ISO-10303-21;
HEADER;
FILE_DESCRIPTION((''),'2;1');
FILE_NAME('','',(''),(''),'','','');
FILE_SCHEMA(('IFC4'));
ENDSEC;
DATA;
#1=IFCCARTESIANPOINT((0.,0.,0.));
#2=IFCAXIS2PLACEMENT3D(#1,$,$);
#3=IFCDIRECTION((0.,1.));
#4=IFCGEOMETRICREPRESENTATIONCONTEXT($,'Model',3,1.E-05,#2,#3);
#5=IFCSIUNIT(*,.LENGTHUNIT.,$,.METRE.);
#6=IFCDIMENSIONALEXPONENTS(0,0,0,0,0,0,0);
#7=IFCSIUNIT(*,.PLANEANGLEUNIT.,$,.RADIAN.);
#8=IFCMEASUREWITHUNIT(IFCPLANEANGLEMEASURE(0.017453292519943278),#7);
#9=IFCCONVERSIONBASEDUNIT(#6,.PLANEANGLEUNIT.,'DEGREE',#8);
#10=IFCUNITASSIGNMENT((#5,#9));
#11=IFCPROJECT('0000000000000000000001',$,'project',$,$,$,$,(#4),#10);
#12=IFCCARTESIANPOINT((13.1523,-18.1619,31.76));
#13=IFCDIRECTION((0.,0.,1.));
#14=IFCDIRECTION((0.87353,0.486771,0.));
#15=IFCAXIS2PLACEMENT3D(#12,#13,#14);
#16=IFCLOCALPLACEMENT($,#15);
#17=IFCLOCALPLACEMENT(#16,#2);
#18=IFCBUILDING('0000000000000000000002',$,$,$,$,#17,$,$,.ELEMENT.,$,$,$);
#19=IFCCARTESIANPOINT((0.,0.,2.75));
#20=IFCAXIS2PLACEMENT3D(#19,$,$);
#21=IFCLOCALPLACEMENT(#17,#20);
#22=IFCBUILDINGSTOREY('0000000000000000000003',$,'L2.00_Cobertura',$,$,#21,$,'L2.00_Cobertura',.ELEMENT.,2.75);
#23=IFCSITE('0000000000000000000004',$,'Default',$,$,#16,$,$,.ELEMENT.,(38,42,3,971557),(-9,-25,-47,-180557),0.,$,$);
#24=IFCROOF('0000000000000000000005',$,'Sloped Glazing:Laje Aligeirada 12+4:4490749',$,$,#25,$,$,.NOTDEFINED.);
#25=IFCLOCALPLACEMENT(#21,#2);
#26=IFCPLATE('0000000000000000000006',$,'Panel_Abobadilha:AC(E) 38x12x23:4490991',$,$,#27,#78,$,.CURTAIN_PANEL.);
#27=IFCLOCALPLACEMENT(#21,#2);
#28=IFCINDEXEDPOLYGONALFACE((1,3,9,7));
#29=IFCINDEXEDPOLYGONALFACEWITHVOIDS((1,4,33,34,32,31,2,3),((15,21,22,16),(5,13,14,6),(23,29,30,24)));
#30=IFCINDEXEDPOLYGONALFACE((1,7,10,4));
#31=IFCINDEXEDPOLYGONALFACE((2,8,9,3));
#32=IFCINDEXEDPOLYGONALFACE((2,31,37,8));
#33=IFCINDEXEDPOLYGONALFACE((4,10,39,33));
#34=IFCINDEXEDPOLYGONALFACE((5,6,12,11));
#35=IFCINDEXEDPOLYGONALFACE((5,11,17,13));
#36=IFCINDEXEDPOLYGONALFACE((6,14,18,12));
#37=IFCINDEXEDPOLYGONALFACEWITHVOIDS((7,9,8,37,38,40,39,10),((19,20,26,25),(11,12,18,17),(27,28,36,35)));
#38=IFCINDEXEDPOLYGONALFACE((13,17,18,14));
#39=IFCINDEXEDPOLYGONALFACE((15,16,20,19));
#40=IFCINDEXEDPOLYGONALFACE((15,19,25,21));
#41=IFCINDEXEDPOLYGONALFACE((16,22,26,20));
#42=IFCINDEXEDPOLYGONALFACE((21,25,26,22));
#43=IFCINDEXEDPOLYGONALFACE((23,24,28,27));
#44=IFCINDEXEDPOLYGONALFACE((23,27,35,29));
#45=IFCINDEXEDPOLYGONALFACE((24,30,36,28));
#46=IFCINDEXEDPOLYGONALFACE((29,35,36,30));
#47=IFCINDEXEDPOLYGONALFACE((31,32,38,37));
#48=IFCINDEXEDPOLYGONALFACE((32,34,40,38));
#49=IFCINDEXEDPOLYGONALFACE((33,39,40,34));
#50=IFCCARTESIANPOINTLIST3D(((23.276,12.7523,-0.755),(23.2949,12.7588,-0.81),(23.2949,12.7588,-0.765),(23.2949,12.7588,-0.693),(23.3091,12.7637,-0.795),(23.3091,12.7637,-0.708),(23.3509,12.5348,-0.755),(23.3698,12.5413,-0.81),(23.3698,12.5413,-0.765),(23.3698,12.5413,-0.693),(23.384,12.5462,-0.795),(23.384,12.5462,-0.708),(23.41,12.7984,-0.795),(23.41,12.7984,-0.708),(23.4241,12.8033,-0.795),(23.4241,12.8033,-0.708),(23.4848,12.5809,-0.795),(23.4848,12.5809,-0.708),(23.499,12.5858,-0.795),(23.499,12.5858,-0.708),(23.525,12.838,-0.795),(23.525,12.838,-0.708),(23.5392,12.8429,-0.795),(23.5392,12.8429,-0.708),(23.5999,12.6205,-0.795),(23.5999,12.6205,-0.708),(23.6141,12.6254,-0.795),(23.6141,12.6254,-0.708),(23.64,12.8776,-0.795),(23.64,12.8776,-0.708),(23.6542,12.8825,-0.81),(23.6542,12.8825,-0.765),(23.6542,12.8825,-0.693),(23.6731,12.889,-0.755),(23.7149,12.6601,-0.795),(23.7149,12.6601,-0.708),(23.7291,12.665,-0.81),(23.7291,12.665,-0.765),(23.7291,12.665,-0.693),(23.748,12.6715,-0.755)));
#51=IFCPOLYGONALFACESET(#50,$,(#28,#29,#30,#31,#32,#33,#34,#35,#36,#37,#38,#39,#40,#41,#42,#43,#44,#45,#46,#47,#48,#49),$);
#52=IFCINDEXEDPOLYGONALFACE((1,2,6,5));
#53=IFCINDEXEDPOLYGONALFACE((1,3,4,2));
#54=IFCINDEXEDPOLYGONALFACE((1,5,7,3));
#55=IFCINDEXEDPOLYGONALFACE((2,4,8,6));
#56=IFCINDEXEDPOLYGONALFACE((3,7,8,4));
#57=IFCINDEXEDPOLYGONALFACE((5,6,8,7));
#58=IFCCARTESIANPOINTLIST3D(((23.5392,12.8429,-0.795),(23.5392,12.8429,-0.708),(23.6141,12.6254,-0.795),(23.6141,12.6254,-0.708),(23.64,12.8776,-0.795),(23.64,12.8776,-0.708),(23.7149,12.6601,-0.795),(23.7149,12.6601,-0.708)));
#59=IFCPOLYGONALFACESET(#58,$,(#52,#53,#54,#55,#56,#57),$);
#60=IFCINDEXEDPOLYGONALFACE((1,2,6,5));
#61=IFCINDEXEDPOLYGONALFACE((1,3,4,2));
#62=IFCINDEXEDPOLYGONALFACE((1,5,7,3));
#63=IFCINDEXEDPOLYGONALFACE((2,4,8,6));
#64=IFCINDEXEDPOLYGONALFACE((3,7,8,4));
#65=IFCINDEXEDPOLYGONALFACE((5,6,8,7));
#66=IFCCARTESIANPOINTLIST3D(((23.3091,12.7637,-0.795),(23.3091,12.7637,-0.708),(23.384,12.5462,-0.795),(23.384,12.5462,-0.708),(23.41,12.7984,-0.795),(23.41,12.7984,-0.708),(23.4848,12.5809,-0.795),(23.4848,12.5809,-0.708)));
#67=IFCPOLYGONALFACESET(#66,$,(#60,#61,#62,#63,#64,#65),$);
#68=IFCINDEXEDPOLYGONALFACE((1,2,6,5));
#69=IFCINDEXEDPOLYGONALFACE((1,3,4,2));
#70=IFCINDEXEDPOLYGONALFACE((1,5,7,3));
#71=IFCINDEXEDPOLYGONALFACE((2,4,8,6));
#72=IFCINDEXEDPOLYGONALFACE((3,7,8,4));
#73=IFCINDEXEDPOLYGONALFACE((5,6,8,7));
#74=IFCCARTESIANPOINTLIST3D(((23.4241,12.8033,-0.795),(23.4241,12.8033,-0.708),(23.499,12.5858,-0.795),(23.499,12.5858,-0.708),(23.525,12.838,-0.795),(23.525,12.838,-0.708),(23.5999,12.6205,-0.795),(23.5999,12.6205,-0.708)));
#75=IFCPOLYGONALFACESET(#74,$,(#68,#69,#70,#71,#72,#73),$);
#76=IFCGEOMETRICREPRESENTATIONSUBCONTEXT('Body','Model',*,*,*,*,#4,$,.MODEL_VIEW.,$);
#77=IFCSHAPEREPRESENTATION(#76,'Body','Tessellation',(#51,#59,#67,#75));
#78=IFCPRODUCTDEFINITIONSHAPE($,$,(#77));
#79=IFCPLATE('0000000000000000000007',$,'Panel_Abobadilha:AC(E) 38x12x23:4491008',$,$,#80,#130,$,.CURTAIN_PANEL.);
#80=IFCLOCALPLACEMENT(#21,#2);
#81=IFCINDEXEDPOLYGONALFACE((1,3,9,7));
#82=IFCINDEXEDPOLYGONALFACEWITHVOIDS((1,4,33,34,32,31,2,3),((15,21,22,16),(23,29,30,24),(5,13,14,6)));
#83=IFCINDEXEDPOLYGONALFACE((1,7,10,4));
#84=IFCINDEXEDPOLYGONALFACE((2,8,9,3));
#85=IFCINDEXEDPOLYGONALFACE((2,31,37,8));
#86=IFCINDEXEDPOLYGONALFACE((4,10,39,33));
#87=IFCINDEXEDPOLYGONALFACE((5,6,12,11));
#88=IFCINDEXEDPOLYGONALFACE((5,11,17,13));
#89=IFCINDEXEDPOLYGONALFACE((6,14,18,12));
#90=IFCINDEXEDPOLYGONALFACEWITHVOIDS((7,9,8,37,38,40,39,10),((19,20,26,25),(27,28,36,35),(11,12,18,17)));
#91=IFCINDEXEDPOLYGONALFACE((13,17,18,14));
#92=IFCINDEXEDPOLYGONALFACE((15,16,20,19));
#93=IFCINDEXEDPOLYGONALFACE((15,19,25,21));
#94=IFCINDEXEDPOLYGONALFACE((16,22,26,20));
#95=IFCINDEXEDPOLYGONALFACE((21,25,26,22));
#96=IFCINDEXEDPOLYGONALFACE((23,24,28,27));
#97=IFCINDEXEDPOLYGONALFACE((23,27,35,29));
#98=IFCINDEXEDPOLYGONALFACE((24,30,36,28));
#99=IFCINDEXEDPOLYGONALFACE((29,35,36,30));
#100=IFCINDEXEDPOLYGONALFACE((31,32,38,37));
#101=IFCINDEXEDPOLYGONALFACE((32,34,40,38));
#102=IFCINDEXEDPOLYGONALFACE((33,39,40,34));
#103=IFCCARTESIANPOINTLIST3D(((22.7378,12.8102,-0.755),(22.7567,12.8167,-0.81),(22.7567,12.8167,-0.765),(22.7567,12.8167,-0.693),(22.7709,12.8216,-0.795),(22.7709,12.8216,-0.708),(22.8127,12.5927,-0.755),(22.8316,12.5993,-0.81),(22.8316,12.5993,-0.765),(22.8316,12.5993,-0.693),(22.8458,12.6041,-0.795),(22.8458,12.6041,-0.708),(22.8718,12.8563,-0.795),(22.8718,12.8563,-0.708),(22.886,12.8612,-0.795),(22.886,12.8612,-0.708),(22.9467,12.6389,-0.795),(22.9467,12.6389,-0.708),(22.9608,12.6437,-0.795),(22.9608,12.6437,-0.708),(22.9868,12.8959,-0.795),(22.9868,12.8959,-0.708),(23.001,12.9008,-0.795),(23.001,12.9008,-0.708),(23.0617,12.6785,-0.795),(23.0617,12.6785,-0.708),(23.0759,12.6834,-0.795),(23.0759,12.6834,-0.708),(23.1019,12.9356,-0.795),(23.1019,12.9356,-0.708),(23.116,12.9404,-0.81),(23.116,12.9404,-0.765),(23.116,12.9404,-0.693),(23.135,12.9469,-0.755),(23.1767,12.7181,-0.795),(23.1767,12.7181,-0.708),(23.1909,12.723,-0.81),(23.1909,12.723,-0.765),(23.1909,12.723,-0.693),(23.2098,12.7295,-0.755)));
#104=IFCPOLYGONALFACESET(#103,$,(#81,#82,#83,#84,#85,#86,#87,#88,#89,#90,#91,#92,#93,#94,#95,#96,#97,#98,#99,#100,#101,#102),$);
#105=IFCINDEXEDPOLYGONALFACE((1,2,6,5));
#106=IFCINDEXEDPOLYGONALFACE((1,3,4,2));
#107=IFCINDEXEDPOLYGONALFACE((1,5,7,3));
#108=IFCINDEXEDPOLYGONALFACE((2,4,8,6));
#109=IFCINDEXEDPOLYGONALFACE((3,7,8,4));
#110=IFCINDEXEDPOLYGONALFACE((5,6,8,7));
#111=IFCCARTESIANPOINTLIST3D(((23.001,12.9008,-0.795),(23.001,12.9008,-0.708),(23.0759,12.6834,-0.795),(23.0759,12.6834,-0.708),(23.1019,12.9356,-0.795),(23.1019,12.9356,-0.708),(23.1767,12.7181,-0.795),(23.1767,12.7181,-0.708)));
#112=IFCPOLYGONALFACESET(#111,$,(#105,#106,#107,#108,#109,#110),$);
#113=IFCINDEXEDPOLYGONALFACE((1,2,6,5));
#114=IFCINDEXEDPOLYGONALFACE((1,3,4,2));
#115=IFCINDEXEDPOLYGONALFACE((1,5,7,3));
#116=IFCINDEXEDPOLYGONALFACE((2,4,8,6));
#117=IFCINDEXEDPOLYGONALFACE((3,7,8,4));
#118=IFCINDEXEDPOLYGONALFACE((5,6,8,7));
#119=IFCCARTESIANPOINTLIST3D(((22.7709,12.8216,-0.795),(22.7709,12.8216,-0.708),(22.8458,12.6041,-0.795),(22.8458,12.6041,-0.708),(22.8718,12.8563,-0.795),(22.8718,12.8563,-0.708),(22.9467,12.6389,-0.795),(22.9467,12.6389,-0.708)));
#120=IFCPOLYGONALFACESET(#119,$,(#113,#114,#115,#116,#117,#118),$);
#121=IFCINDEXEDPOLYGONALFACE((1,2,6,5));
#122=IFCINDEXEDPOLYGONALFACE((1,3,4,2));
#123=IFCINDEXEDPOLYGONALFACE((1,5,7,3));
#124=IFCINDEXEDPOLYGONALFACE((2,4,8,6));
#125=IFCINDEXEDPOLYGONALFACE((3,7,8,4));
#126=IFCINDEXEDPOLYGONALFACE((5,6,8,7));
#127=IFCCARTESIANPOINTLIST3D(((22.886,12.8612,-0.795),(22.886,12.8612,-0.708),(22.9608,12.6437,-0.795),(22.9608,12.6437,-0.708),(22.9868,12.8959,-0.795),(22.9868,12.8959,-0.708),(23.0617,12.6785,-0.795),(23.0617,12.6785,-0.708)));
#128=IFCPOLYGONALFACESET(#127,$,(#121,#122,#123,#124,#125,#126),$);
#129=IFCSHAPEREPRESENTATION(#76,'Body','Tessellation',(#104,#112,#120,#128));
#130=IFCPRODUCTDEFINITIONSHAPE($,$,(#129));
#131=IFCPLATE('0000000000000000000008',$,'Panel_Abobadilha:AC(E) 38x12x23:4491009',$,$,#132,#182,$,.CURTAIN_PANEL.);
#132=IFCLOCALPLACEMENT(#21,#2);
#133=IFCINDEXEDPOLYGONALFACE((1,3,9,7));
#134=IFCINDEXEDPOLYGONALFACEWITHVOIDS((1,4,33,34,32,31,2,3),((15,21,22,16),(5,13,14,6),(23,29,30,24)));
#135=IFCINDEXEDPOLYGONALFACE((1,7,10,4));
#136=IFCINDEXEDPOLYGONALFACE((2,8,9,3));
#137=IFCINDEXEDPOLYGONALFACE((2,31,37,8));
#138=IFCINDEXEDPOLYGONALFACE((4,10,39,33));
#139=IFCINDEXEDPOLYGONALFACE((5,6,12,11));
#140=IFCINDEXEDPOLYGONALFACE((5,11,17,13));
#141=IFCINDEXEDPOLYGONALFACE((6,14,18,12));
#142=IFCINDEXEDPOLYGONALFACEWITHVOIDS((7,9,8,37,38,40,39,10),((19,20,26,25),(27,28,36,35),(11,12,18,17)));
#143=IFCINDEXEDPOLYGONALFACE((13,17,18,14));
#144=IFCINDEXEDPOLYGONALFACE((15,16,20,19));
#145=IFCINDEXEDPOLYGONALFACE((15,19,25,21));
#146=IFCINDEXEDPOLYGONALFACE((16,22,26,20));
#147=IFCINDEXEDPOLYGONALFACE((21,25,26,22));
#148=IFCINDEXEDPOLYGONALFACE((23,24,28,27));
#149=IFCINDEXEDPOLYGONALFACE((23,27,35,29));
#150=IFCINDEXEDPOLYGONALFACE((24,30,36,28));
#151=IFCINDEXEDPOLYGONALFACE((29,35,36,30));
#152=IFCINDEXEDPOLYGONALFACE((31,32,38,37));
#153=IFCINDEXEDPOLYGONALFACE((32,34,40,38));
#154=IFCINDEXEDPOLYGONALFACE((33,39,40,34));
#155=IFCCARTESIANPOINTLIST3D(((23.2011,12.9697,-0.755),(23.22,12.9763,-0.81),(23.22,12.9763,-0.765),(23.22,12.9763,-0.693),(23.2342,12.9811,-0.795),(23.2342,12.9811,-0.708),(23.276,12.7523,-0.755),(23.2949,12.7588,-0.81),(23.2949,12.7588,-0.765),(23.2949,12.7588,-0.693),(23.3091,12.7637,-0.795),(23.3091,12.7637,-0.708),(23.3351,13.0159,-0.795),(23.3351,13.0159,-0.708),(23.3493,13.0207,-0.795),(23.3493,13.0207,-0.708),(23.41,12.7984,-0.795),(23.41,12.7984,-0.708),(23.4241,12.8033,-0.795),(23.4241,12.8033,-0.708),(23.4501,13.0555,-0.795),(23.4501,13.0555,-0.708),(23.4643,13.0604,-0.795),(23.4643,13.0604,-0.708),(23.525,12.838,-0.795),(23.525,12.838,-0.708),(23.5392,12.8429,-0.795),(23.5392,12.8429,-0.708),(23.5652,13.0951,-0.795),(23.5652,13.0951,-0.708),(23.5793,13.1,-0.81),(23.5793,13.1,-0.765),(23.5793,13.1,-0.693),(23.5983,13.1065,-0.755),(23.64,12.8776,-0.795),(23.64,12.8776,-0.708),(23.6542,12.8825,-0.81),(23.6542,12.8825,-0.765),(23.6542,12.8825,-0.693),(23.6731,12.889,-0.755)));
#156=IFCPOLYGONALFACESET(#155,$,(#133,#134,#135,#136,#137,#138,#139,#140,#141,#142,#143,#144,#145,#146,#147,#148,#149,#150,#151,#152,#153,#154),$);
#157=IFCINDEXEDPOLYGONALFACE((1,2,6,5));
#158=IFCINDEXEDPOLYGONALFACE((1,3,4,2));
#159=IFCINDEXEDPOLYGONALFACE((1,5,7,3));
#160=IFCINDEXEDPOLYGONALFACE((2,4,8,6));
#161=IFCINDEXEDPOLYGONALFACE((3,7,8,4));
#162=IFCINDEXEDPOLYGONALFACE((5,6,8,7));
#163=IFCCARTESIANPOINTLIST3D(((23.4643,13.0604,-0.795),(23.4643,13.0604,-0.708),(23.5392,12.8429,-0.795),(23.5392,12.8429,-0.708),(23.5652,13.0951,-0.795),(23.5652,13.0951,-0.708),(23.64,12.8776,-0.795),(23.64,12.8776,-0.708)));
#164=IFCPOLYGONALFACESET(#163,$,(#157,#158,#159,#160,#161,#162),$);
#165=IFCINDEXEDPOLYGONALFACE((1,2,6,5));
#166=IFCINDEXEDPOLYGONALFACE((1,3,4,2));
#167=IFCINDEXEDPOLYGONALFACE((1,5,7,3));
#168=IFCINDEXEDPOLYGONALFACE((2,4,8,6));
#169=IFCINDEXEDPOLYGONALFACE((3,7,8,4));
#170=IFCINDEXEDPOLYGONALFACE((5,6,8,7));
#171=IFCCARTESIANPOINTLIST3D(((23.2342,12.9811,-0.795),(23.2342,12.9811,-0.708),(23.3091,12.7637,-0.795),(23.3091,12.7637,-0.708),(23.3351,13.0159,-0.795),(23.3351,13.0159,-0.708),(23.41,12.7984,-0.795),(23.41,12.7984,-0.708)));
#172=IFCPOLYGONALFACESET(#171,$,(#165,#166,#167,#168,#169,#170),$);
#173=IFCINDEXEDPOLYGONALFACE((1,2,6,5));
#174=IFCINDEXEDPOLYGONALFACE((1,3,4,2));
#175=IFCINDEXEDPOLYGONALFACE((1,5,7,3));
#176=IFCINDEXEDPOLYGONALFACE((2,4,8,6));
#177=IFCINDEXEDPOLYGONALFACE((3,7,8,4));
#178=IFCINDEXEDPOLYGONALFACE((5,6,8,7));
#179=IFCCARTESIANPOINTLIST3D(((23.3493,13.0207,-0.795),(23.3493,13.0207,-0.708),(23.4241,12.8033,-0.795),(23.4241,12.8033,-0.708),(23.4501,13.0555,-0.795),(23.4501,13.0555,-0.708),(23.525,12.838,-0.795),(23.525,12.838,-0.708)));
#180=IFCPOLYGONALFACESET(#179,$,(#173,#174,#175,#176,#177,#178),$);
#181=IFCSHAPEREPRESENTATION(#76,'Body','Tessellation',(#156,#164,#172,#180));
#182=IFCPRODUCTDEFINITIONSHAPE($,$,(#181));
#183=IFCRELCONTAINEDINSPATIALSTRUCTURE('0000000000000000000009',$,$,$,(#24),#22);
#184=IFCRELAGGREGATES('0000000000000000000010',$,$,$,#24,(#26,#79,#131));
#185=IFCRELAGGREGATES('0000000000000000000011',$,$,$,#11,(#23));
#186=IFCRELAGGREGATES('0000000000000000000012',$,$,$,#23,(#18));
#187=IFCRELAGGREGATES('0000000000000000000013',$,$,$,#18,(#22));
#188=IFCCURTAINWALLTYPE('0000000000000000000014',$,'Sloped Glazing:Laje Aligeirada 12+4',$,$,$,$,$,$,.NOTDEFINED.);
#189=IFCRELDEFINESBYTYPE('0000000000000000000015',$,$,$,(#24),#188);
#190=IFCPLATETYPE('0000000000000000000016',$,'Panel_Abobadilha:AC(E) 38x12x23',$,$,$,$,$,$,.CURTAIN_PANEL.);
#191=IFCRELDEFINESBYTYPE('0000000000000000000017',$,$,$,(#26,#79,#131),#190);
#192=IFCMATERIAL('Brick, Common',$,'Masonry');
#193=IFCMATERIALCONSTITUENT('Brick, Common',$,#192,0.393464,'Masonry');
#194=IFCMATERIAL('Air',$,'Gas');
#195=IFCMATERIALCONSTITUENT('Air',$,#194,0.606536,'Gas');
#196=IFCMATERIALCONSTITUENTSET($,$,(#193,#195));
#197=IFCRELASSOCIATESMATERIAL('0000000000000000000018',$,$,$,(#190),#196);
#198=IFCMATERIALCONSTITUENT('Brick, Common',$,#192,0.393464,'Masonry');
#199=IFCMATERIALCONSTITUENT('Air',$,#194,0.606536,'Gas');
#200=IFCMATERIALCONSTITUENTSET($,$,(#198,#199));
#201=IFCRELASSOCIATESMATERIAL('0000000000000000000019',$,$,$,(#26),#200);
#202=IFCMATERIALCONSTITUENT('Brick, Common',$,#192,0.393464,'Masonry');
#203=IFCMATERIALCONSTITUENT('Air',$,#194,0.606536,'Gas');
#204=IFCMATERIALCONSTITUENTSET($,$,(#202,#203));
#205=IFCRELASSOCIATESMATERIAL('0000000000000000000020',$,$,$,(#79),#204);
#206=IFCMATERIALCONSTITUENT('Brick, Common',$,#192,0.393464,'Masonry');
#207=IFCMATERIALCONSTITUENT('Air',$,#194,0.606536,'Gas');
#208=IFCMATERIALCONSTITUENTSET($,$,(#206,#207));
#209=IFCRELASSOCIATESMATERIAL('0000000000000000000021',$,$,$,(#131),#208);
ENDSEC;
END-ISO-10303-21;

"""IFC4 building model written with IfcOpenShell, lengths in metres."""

from ifc_helpers import new_model, entity, si_unit, converted_unit, direction, frame, origin, place, context, subcontext, project, spatial, indexed_curve, outline, extrude, source, transform, mapped, material, constituent, constituent_set, type_object, type_shapes, element, aggregate, save


model = new_model("IFC4")

# Units and contexts
model_context = context("Model", 3, precision=1e-05, world=origin(), true_north=direction((0.0, 1.0)))
body_context = subcontext(model_context, "Body", "Model", "MODEL_VIEW")
ifc_project = project(units=[si_unit("LENGTHUNIT", "METRE"), converted_unit("PLANEANGLEUNIT", "DEGREE", entity("IfcPlaneAngleMeasure", 0.017453292519943278), si_unit("PLANEANGLEUNIT", "RADIAN"), dimensions=[0, 0, 0, 0, 0, 0, 0])], contexts=[model_context])

# Site, building, storey
site_placement = place(None, frame((13.1523, -18.1619, 31.76), z_axis=(0.0, 0.0, 1.0), x_axis=(0.87353, 0.486771, 0.0)))
site = spatial("IfcSite", under=ifc_project, at=site_placement, Name="Default", CompositionType="ELEMENT", RefLatitude=(38, 42, 3, 971557), RefLongitude=(-9, -25, -47, -180557), RefElevation=0.0)
building_placement = place(site_placement, origin())
building = spatial("IfcBuilding", under=site, at=building_placement, CompositionType="ELEMENT")
storey_placement = place(building_placement, frame((0.0, 0.0, 2.75)))
storey = spatial("IfcBuildingStorey", under=building, at=storey_placement, Name="L2.00_Cobertura", LongName="L2.00_Cobertura", CompositionType="ELEMENT", Elevation=2.75)

# Roof, plates
curtain_wall_type = type_object("IfcCurtainWallType", Name="Sloped Glazing:Laje Aligeirada 12+4", PredefinedType="NOTDEFINED")
roof_placement = place(storey_placement, frame((0.0, 0.0, -2.75)))
roof = element("IfcRoof", 1, at=roof_placement, inside=storey, type_object=curtain_wall_type, Name="Sloped Glazing:Laje Aligeirada 12+4:4490749", PredefinedType="NOTDEFINED")
ifc_material_1 = material(Name="Brick, Common", Category="Masonry")
ifc_constituent_1 = constituent(ifc_material_1, Name="Brick, Common", Category="Masonry", fraction=0.393464)
ifc_material_2 = material(Name="Air", Category="Gas")
ifc_constituent_2 = constituent(ifc_material_2, Name="Air", Category="Gas", fraction=0.606536)
ifc_constituent_set_1 = constituent_set(constituents=[ifc_constituent_1, ifc_constituent_2])
ifc_constituent_3 = constituent(ifc_material_1, Name="Brick, Common", Category="Masonry", fraction=0.393464)
ifc_constituent_4 = constituent(ifc_material_2, Name="Air", Category="Gas", fraction=0.606536)
ifc_constituent_set_2 = constituent_set(constituents=[ifc_constituent_3, ifc_constituent_4])
plate_type = type_object("IfcPlateType", Name="Panel_Abobadilha:AC(E) 38x12x23", PredefinedType="CURTAIN_PANEL", material=ifc_constituent_set_2)
shared_shape_1 = source(origin(), body_context, "Body", "SweptSolid", [
    extrude(outline(indexed_curve([(-0.19, -0.0543), (0.19, -0.0543), (0.19, -0.0093), (0.21, 0.0007), (0.19, 0.0628), (-0.19, 0.0628), (-0.21, 0.0007), (-0.19, -0.0093), (-0.19, -0.0543)], self_intersect=False), holes=[indexed_curve([(-0.0683, 0.0477), (-0.0683, -0.0393), (-0.175, -0.0393), (-0.175, 0.0477), (-0.0683, 0.0477)], self_intersect=False), indexed_curve([(0.0533, 0.0477), (0.0533, -0.0393), (-0.0533, -0.0393), (-0.0533, 0.0477), (0.0533, 0.0477)], self_intersect=False), indexed_curve([(0.175, 0.0477), (0.175, -0.0393), (0.0683, -0.0393), (0.0683, 0.0477), (0.175, 0.0477)], self_intersect=False)]), frame((0.0, 0.0543, 0.0)), (0.0, 0.0, 1.0), 0.23),
    extrude(outline(indexed_curve([(-0.0533, -0.0435), (0.0533, -0.0435), (0.0533, 0.0435), (-0.0533, 0.0435), (-0.0533, -0.0435)], self_intersect=False)), frame((0.1217, 0.0585, 0.0), z_axis=(0.0, 0.0, 1.0), x_axis=(-1.0, 0.0, 0.0)), (0.0, 0.0, 1.0), 0.23),
    extrude(outline(indexed_curve([(-0.0533, -0.0435), (0.0533, -0.0435), (0.0533, 0.0435), (-0.0533, 0.0435), (-0.0533, -0.0435)], self_intersect=False)), frame((-0.1217, 0.0585, 0.0), z_axis=(0.0, 0.0, 1.0), x_axis=(-1.0, 0.0, 0.0)), (0.0, 0.0, 1.0), 0.23),
    extrude(outline(indexed_curve([(-0.0533, -0.0435), (0.0533, -0.0435), (0.0533, 0.0435), (-0.0533, 0.0435), (-0.0533, -0.0435)], self_intersect=False)), frame((0.0, 0.0585, 0.0), z_axis=(0.0, 0.0, 1.0), x_axis=(-1.0, 0.0, 0.0)), (0.0, 0.0, 1.0), 0.23),
])
type_shapes(plate_type, [shared_shape_1])
plate_1_placement = place(roof_placement, frame((23.4746, 12.8206, 1.94), z_axis=(0.325568, -0.945519, 0.0), x_axis=(0.945519, 0.325568, 0.0)))
plate_1 = element("IfcPlate", 2, at=plate_1_placement, type_object=plate_type, material=ifc_constituent_set_1, Name="Panel_Abobadilha:AC(E) 38x12x23:4490991", PredefinedType="CURTAIN_PANEL", context=body_context, shape_type="MappedRepresentation", body=[
    mapped(shared_shape_1, transform((0.0, 0.0, 0.0), scale=1.0)),
])
ifc_constituent_5 = constituent(ifc_material_1, Name="Brick, Common", Category="Masonry", fraction=0.393464)
ifc_constituent_6 = constituent(ifc_material_2, Name="Air", Category="Gas", fraction=0.606536)
ifc_constituent_set_3 = constituent_set(constituents=[ifc_constituent_5, ifc_constituent_6])
plate_2_placement = place(roof_placement, frame((22.9364, 12.8786, 1.94), z_axis=(0.325568, -0.945519, 0.0), x_axis=(0.945519, 0.325568, 0.0)))
plate_2 = element("IfcPlate", 3, at=plate_2_placement, type_object=plate_type, material=ifc_constituent_set_3, Name="Panel_Abobadilha:AC(E) 38x12x23:4491008", PredefinedType="CURTAIN_PANEL", context=body_context, shape_type="MappedRepresentation", body=[
    mapped(shared_shape_1, transform((0.0, 0.0, 0.0), scale=1.0)),
])
ifc_constituent_7 = constituent(ifc_material_1, Name="Brick, Common", Category="Masonry", fraction=0.393464)
ifc_constituent_8 = constituent(ifc_material_2, Name="Air", Category="Gas", fraction=0.606536)
ifc_constituent_set_4 = constituent_set(constituents=[ifc_constituent_7, ifc_constituent_8])
plate_3_placement = place(roof_placement, frame((23.3997, 13.0381, 1.94), z_axis=(0.325568, -0.945519, 0.0), x_axis=(0.945519, 0.325568, 0.0)))
plate_3 = element("IfcPlate", 4, at=plate_3_placement, type_object=plate_type, material=ifc_constituent_set_4, Name="Panel_Abobadilha:AC(E) 38x12x23:4491009", PredefinedType="CURTAIN_PANEL", context=body_context, shape_type="MappedRepresentation", body=[
    mapped(shared_shape_1, transform((0.0, 0.0, 0.0), scale=1.0)),
])
aggregate(roof, [plate_1, plate_2, plate_3])

save(model, "model.ifc")
